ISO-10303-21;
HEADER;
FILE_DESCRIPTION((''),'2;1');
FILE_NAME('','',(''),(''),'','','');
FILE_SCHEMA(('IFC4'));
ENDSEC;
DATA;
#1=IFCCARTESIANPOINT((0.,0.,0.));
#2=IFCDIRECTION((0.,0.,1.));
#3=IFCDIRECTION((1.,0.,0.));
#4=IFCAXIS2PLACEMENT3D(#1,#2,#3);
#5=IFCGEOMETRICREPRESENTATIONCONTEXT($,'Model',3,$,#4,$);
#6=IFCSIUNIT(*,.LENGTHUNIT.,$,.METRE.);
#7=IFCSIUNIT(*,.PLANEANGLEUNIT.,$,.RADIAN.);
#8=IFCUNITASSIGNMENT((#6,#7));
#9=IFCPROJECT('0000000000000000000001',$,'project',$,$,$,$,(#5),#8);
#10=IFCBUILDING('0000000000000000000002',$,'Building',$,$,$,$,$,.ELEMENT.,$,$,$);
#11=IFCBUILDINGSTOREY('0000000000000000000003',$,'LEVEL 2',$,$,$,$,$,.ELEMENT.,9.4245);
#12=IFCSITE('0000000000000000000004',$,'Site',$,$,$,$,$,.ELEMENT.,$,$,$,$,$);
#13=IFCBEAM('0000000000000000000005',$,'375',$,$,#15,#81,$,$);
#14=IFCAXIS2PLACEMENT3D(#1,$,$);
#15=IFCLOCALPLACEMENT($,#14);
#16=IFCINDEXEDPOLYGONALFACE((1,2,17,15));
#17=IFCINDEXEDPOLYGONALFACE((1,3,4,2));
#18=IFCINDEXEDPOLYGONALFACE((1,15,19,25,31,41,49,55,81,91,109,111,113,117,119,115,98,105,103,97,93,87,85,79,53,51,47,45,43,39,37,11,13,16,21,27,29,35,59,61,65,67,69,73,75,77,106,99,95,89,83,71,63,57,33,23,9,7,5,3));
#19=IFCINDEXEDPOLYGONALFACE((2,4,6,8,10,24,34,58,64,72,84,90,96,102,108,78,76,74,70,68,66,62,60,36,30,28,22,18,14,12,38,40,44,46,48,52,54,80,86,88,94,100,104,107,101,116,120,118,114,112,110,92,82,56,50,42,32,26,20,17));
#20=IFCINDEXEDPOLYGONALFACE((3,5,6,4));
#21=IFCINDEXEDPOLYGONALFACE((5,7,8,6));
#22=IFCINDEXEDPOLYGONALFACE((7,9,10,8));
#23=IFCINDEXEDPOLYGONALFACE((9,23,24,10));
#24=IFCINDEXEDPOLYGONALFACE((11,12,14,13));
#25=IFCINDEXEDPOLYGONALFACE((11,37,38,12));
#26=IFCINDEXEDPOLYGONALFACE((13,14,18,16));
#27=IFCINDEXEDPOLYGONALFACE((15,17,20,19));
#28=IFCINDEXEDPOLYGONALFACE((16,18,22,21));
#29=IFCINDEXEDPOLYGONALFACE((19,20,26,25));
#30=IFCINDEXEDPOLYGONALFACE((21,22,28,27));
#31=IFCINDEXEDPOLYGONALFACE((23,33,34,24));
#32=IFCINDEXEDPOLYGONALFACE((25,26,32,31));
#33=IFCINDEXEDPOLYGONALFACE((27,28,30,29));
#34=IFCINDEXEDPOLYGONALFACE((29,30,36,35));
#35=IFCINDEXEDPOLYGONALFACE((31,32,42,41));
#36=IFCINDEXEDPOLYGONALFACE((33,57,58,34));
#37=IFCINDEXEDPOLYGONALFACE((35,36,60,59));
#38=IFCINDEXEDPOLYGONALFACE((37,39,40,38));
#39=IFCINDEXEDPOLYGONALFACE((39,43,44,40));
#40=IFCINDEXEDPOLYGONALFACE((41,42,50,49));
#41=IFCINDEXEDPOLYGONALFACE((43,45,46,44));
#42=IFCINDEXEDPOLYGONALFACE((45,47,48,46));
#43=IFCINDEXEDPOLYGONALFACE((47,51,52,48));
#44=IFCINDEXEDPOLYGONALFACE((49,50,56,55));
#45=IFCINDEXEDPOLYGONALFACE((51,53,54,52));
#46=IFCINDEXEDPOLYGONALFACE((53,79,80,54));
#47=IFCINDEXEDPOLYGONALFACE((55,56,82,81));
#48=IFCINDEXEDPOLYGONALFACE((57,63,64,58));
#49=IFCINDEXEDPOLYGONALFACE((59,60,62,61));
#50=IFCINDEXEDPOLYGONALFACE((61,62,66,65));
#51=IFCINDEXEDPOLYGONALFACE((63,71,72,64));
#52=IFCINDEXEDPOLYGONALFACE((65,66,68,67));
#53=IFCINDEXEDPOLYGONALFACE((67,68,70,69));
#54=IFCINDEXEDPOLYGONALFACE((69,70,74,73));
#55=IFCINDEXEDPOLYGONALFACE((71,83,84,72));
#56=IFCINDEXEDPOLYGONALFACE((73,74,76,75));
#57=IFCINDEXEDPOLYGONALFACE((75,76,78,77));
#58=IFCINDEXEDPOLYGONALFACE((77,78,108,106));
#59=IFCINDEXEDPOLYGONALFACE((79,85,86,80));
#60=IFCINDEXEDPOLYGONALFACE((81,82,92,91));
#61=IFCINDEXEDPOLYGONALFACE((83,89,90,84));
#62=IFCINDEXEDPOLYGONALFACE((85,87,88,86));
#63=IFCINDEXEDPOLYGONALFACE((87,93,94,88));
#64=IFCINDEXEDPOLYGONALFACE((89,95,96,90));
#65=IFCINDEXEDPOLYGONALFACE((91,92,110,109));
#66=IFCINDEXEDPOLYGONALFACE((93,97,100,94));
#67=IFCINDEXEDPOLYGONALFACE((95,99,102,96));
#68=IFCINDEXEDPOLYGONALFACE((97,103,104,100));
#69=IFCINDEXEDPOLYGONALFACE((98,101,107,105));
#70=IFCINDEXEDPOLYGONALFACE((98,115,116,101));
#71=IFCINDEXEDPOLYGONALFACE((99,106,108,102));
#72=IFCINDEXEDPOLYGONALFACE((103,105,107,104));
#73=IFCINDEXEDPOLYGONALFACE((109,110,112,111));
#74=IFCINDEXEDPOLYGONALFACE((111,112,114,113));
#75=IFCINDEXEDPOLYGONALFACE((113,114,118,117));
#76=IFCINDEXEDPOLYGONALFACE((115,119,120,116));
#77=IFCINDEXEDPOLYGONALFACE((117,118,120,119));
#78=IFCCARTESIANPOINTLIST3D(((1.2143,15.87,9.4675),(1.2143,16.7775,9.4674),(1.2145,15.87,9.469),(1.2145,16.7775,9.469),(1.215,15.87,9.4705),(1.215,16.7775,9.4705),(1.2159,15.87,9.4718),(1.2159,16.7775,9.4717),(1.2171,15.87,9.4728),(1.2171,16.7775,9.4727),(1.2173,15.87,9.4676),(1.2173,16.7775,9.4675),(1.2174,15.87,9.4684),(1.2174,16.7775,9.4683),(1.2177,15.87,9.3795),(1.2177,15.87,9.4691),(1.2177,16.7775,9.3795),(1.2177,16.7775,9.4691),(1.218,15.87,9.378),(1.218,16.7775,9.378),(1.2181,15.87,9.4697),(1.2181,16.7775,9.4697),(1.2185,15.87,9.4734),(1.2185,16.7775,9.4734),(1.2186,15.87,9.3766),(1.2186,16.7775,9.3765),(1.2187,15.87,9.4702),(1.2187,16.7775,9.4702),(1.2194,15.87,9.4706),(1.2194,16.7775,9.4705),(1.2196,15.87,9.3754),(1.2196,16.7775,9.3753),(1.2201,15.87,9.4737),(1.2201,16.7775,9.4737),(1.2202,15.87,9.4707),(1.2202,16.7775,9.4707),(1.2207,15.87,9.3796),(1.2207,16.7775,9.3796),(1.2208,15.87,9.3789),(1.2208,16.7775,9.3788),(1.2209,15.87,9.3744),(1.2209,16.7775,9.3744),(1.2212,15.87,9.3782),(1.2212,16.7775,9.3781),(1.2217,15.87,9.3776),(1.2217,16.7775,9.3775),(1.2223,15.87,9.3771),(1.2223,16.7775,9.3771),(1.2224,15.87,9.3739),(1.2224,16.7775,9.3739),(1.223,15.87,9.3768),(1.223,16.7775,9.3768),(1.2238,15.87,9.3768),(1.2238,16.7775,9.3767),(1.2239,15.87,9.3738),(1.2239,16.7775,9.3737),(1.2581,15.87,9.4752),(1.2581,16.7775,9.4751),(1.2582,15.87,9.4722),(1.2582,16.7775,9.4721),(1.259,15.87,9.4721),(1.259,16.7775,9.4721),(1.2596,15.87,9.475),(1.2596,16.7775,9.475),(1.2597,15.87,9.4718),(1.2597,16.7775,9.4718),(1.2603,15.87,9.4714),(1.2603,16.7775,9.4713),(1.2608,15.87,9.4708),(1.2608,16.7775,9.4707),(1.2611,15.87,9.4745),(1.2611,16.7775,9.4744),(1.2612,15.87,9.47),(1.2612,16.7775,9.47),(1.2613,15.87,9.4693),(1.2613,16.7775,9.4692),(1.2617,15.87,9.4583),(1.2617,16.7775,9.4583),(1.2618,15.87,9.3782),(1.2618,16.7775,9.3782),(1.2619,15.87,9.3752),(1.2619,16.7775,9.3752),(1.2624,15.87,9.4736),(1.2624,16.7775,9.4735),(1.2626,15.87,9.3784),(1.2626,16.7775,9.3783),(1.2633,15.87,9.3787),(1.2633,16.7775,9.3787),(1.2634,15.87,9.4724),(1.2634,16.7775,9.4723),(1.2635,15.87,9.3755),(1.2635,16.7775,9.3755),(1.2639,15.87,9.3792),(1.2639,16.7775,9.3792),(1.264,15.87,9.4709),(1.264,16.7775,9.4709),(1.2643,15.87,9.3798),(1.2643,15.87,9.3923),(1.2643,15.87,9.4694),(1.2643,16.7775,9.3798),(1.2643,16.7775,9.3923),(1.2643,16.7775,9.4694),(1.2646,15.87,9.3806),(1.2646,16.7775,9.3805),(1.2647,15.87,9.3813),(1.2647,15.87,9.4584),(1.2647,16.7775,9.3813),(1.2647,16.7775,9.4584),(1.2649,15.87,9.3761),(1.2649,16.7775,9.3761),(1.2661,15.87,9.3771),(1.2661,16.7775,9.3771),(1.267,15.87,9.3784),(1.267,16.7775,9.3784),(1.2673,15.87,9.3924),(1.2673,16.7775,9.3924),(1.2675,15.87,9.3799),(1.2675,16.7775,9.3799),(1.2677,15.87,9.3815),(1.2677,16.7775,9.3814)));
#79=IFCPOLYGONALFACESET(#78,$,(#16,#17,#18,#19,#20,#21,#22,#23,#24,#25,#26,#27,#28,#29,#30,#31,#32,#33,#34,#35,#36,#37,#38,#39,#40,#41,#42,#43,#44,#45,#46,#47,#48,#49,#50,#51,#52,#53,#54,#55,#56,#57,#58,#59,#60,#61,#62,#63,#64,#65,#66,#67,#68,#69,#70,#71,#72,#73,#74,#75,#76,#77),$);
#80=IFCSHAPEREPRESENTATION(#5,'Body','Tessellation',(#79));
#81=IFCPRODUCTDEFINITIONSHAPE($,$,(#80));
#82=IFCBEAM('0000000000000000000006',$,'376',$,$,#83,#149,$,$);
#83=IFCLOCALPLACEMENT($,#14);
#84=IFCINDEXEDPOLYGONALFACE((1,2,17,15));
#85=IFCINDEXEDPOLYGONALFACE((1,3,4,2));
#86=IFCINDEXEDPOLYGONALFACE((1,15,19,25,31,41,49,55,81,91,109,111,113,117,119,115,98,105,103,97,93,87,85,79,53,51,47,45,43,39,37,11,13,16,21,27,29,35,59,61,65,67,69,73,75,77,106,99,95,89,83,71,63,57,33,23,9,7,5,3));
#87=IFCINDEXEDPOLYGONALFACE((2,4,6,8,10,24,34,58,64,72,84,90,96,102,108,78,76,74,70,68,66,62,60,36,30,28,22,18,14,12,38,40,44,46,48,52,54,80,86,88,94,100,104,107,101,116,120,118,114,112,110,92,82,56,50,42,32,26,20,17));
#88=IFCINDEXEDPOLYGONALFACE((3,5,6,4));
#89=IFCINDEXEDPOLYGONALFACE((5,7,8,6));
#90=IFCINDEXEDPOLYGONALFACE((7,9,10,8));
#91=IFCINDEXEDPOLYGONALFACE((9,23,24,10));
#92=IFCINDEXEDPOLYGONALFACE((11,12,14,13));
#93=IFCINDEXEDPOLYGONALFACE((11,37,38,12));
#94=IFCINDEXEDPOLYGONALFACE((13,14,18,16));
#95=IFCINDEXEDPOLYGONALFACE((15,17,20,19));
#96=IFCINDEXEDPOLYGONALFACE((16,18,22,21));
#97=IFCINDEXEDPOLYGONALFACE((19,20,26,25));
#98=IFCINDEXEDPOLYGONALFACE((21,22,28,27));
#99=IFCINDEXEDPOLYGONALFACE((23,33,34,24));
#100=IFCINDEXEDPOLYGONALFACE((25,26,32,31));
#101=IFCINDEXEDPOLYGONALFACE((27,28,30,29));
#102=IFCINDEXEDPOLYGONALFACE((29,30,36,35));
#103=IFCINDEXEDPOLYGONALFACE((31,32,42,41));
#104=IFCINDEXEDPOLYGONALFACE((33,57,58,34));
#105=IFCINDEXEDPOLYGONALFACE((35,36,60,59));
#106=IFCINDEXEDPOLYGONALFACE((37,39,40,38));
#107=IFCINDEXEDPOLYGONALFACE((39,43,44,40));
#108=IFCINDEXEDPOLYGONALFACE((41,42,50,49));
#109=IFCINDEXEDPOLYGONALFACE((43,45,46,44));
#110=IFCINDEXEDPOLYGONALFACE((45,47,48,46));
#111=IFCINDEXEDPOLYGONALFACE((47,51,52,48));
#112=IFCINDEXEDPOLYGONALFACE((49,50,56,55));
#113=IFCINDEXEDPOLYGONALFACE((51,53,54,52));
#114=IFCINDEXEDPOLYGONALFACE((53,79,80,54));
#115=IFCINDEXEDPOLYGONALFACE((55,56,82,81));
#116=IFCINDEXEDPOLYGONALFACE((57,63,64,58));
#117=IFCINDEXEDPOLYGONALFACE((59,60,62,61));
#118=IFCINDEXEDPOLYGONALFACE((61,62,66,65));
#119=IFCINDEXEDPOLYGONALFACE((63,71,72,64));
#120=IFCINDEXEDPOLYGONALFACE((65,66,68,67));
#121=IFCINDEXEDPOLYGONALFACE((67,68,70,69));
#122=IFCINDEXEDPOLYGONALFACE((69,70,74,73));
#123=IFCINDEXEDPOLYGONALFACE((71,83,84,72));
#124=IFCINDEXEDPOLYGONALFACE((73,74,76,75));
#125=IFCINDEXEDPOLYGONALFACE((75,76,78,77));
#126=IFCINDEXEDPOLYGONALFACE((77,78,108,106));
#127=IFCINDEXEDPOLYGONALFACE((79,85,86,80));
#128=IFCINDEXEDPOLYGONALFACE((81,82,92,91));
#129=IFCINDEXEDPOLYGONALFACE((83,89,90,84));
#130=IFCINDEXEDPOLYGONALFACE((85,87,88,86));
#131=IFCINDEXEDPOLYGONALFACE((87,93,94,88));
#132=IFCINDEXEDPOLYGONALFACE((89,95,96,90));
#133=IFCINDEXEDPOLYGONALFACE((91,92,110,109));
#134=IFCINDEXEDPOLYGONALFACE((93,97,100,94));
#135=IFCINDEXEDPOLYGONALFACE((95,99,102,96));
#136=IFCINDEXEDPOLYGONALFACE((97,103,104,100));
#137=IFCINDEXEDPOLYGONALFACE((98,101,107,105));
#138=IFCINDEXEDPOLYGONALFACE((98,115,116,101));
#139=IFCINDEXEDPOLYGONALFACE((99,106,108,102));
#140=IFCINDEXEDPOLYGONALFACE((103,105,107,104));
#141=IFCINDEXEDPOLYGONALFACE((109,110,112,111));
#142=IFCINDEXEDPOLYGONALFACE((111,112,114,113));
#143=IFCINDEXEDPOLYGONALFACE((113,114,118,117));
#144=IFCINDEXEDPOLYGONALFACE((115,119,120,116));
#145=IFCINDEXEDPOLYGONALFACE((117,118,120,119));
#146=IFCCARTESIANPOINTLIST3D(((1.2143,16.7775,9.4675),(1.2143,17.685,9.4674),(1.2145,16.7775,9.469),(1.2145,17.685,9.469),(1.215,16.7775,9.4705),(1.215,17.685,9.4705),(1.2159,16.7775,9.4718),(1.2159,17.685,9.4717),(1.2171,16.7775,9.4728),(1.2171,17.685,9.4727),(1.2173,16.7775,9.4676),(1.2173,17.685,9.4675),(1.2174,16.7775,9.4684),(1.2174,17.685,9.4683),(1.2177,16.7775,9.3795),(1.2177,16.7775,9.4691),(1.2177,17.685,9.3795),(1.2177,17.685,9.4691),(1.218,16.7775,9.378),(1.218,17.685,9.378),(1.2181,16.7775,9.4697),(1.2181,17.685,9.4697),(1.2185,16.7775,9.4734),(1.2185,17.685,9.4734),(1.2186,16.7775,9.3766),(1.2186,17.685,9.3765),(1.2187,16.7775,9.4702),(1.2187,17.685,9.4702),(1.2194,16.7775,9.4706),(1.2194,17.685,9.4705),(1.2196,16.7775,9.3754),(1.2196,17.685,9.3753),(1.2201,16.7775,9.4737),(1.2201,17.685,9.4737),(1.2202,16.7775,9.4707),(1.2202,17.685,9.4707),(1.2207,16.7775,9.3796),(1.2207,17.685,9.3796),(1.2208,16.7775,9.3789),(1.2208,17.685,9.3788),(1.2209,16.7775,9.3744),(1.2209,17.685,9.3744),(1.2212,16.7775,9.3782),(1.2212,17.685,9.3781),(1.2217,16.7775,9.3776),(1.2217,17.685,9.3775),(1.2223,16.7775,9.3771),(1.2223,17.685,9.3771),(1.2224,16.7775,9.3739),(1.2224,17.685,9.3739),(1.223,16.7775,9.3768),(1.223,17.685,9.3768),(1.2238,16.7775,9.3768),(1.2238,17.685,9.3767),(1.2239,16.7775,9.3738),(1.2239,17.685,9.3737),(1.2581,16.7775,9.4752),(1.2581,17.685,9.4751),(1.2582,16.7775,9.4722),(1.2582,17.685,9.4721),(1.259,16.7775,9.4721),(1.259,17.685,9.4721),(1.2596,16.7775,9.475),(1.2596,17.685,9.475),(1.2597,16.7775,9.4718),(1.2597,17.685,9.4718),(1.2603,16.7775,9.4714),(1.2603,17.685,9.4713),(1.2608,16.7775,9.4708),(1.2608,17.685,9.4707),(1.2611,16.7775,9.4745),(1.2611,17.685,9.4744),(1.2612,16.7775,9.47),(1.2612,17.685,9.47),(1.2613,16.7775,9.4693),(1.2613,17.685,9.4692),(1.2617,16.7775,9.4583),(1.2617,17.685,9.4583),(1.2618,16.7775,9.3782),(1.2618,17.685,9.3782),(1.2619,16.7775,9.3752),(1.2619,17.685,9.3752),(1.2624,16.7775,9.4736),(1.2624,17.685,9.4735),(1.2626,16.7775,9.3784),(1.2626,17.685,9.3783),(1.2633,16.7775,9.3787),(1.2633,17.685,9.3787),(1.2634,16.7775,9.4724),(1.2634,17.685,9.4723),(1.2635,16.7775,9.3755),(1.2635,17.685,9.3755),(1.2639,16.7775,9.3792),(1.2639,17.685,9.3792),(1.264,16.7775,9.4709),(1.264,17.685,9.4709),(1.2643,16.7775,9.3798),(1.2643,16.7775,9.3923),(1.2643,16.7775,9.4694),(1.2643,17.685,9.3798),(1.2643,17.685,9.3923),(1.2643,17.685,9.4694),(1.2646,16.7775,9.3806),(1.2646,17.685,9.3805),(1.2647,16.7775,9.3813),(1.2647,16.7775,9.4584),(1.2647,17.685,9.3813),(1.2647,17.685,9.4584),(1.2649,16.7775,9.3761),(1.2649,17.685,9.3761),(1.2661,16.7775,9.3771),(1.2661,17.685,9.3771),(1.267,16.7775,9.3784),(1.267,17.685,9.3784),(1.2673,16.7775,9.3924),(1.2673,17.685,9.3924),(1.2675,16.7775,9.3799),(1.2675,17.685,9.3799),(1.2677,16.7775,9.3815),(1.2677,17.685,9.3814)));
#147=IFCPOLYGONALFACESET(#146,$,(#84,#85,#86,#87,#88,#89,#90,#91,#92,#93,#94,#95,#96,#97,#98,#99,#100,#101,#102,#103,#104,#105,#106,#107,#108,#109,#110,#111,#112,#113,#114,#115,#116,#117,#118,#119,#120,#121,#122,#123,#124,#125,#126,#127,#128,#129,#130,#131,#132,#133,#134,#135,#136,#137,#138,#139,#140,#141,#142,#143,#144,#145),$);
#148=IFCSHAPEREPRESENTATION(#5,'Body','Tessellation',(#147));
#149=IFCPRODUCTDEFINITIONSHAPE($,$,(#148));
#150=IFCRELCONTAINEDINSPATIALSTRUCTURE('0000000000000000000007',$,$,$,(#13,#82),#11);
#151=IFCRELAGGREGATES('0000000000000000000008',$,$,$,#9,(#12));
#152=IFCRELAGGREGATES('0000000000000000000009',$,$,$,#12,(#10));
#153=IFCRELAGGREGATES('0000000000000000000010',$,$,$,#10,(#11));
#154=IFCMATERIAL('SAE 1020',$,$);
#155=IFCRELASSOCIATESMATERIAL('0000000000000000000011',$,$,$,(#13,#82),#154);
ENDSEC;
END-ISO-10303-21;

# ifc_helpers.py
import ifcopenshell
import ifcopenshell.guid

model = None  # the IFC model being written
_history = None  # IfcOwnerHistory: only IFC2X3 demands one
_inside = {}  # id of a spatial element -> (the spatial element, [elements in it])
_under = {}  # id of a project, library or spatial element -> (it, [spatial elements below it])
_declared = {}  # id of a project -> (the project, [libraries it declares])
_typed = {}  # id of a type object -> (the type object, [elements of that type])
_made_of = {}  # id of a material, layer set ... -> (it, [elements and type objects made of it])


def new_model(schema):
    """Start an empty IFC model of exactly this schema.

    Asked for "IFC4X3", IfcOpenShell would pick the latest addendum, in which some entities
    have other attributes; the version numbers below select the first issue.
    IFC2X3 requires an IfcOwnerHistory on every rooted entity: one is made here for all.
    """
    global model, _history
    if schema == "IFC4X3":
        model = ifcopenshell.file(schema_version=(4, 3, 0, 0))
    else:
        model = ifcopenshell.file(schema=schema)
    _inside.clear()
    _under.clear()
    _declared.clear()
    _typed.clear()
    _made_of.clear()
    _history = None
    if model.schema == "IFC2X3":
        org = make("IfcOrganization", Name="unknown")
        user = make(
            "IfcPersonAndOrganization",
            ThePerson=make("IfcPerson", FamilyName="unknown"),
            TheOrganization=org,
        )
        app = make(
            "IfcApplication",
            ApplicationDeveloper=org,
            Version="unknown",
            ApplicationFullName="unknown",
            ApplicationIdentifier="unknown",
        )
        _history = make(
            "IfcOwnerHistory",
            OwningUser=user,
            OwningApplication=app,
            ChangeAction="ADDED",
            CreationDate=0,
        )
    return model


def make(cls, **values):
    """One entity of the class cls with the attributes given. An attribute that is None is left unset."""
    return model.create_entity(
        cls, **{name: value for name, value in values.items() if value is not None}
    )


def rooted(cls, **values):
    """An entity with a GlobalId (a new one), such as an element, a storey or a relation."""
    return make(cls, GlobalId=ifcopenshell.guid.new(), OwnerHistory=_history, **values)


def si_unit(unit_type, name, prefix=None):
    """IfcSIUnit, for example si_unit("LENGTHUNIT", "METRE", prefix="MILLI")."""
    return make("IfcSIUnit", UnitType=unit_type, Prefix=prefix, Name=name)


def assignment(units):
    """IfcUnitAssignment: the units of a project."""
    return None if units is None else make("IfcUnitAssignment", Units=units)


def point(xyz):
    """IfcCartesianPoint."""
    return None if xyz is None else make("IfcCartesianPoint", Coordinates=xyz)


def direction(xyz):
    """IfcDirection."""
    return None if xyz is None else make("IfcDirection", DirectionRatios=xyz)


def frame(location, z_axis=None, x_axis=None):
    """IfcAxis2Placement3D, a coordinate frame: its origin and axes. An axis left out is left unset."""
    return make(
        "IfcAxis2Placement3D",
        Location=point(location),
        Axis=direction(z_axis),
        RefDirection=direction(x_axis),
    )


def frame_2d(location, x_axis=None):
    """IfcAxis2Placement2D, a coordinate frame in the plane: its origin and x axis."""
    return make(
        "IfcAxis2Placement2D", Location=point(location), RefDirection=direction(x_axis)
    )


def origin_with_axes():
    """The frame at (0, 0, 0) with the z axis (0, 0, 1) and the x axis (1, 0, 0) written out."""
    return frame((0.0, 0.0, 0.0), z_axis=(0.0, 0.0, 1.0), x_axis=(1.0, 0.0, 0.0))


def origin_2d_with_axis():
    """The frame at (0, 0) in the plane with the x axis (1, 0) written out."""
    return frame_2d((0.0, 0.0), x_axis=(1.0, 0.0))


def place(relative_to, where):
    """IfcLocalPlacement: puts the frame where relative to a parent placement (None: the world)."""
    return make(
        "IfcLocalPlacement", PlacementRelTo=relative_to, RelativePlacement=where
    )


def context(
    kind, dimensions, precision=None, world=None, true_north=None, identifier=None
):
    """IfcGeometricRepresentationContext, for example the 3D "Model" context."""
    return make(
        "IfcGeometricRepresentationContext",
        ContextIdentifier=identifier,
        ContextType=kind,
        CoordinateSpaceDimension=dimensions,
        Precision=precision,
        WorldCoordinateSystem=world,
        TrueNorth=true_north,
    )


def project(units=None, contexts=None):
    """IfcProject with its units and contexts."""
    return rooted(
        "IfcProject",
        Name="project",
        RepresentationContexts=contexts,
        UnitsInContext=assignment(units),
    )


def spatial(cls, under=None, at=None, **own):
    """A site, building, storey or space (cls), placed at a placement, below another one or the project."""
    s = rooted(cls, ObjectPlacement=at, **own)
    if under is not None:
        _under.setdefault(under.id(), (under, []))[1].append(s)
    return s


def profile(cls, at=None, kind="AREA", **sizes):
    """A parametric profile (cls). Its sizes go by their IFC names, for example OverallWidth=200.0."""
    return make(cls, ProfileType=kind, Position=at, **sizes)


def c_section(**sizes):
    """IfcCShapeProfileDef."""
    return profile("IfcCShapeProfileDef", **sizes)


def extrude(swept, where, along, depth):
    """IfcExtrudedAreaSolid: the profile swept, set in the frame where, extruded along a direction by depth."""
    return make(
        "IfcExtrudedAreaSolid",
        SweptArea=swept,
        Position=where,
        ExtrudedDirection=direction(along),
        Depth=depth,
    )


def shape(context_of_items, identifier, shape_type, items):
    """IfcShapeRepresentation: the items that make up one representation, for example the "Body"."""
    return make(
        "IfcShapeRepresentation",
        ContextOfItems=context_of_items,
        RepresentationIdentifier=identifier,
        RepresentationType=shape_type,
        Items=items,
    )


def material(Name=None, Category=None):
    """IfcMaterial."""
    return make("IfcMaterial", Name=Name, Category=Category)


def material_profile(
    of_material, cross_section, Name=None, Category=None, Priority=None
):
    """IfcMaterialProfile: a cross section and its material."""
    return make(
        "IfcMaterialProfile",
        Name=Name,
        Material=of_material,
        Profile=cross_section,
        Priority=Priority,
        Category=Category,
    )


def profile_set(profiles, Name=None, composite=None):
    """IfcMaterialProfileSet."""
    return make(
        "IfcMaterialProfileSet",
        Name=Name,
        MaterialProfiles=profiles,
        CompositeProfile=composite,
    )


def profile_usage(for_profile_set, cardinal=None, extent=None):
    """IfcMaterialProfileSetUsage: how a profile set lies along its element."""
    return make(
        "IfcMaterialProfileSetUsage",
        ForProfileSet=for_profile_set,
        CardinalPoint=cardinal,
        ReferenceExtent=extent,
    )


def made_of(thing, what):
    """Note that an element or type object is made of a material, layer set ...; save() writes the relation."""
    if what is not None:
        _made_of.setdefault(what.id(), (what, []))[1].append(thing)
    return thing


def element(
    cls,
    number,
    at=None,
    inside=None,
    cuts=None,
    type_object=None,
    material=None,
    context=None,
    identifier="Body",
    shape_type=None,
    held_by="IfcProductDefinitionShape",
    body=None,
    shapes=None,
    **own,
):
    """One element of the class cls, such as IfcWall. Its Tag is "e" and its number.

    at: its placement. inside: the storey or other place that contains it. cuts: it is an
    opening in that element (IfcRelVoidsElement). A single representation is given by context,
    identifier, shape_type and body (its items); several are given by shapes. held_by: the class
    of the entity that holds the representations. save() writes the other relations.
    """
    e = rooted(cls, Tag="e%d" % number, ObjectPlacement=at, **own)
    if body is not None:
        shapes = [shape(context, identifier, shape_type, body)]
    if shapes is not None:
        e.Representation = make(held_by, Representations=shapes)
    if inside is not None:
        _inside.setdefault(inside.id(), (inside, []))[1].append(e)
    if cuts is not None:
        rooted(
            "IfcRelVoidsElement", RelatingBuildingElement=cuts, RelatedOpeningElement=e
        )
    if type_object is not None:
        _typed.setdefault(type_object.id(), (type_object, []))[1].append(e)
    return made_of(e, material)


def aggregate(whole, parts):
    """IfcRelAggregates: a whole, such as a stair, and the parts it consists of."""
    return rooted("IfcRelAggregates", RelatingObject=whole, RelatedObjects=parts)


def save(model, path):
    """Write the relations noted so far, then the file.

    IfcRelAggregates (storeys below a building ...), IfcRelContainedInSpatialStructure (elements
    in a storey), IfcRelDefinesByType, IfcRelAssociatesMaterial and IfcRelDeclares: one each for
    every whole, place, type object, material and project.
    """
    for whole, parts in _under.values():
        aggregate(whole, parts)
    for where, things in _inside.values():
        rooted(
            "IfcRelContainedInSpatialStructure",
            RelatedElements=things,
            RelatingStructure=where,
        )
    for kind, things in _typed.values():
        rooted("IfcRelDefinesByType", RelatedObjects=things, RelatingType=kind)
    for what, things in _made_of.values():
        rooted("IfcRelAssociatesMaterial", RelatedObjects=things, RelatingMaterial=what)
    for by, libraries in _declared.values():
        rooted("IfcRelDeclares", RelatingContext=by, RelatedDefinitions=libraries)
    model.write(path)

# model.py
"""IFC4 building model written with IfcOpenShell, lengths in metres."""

from ifc_helpers import new_model, si_unit, frame, origin_with_axes, origin_2d_with_axis, place, context, project, spatial, c_section, extrude, material, material_profile, profile_set, profile_usage, element, save


model = new_model("IFC4")

# Units and contexts
model_context = context("Model", 3, world=origin_with_axes())
ifc_project = project(units=[si_unit("LENGTHUNIT", "METRE"), si_unit("PLANEANGLEUNIT", "RADIAN")], contexts=[model_context])

# Site, building, storey
site = spatial("IfcSite", under=ifc_project, Name="Site", CompositionType="ELEMENT")
building = spatial("IfcBuilding", under=site, Name="Building", CompositionType="ELEMENT")
storey = spatial("IfcBuildingStorey", under=building, Name="LEVEL 2", CompositionType="ELEMENT", Elevation=9.4245)

# Beams
ifc_material = material(Name="SAE 1020")
ifc_material_profile_1 = material_profile(ifc_material, c_section(Depth=0.1, Width=0.05, WallThickness=0.003, Girth=0.017, InternalFilletRadius=0.003, at=origin_2d_with_axis()))
ifc_profile_set_1 = profile_set([ifc_material_profile_1])
ifc_profile_usage_1 = profile_usage(ifc_profile_set_1, cardinal=10)
beam_1_placement = place(None, frame((1.241, 15.87, 9.4245), z_axis=(0.0, 1.0, -0.00003), x_axis=(0.999256, 0.000001, 0.038562)))
element("IfcBeam", 1, at=beam_1_placement, inside=storey, material=ifc_profile_usage_1, Name="375", context=model_context, shape_type="SweptSolid", body=[
    extrude(c_section(Depth=0.1, Width=0.05, WallThickness=0.003, Girth=0.017, InternalFilletRadius=0.003, at=origin_2d_with_axis()), origin_with_axes(), (0.0, 0.0, 1.0), 0.9075),
])
ifc_material_profile_2 = material_profile(ifc_material, c_section(Depth=0.1, Width=0.05, WallThickness=0.003, Girth=0.017, InternalFilletRadius=0.003, at=origin_2d_with_axis()))
ifc_profile_set_2 = profile_set([ifc_material_profile_2])
ifc_profile_usage_2 = profile_usage(ifc_profile_set_2, cardinal=10)
beam_2_placement = place(None, frame((1.241, 16.7775, 9.4245), z_axis=(0.0, 1.0, -0.00003), x_axis=(0.999256, 0.000001, 0.038562)))
element("IfcBeam", 2, at=beam_2_placement, inside=storey, material=ifc_profile_usage_2, Name="376", context=model_context, shape_type="SweptSolid", body=[
    extrude(c_section(Depth=0.1, Width=0.05, WallThickness=0.003, Girth=0.017, InternalFilletRadius=0.003, at=origin_2d_with_axis()), origin_with_axes(), (0.0, 0.0, 1.0), 0.9075),
])

save(model, "model.ifc")
